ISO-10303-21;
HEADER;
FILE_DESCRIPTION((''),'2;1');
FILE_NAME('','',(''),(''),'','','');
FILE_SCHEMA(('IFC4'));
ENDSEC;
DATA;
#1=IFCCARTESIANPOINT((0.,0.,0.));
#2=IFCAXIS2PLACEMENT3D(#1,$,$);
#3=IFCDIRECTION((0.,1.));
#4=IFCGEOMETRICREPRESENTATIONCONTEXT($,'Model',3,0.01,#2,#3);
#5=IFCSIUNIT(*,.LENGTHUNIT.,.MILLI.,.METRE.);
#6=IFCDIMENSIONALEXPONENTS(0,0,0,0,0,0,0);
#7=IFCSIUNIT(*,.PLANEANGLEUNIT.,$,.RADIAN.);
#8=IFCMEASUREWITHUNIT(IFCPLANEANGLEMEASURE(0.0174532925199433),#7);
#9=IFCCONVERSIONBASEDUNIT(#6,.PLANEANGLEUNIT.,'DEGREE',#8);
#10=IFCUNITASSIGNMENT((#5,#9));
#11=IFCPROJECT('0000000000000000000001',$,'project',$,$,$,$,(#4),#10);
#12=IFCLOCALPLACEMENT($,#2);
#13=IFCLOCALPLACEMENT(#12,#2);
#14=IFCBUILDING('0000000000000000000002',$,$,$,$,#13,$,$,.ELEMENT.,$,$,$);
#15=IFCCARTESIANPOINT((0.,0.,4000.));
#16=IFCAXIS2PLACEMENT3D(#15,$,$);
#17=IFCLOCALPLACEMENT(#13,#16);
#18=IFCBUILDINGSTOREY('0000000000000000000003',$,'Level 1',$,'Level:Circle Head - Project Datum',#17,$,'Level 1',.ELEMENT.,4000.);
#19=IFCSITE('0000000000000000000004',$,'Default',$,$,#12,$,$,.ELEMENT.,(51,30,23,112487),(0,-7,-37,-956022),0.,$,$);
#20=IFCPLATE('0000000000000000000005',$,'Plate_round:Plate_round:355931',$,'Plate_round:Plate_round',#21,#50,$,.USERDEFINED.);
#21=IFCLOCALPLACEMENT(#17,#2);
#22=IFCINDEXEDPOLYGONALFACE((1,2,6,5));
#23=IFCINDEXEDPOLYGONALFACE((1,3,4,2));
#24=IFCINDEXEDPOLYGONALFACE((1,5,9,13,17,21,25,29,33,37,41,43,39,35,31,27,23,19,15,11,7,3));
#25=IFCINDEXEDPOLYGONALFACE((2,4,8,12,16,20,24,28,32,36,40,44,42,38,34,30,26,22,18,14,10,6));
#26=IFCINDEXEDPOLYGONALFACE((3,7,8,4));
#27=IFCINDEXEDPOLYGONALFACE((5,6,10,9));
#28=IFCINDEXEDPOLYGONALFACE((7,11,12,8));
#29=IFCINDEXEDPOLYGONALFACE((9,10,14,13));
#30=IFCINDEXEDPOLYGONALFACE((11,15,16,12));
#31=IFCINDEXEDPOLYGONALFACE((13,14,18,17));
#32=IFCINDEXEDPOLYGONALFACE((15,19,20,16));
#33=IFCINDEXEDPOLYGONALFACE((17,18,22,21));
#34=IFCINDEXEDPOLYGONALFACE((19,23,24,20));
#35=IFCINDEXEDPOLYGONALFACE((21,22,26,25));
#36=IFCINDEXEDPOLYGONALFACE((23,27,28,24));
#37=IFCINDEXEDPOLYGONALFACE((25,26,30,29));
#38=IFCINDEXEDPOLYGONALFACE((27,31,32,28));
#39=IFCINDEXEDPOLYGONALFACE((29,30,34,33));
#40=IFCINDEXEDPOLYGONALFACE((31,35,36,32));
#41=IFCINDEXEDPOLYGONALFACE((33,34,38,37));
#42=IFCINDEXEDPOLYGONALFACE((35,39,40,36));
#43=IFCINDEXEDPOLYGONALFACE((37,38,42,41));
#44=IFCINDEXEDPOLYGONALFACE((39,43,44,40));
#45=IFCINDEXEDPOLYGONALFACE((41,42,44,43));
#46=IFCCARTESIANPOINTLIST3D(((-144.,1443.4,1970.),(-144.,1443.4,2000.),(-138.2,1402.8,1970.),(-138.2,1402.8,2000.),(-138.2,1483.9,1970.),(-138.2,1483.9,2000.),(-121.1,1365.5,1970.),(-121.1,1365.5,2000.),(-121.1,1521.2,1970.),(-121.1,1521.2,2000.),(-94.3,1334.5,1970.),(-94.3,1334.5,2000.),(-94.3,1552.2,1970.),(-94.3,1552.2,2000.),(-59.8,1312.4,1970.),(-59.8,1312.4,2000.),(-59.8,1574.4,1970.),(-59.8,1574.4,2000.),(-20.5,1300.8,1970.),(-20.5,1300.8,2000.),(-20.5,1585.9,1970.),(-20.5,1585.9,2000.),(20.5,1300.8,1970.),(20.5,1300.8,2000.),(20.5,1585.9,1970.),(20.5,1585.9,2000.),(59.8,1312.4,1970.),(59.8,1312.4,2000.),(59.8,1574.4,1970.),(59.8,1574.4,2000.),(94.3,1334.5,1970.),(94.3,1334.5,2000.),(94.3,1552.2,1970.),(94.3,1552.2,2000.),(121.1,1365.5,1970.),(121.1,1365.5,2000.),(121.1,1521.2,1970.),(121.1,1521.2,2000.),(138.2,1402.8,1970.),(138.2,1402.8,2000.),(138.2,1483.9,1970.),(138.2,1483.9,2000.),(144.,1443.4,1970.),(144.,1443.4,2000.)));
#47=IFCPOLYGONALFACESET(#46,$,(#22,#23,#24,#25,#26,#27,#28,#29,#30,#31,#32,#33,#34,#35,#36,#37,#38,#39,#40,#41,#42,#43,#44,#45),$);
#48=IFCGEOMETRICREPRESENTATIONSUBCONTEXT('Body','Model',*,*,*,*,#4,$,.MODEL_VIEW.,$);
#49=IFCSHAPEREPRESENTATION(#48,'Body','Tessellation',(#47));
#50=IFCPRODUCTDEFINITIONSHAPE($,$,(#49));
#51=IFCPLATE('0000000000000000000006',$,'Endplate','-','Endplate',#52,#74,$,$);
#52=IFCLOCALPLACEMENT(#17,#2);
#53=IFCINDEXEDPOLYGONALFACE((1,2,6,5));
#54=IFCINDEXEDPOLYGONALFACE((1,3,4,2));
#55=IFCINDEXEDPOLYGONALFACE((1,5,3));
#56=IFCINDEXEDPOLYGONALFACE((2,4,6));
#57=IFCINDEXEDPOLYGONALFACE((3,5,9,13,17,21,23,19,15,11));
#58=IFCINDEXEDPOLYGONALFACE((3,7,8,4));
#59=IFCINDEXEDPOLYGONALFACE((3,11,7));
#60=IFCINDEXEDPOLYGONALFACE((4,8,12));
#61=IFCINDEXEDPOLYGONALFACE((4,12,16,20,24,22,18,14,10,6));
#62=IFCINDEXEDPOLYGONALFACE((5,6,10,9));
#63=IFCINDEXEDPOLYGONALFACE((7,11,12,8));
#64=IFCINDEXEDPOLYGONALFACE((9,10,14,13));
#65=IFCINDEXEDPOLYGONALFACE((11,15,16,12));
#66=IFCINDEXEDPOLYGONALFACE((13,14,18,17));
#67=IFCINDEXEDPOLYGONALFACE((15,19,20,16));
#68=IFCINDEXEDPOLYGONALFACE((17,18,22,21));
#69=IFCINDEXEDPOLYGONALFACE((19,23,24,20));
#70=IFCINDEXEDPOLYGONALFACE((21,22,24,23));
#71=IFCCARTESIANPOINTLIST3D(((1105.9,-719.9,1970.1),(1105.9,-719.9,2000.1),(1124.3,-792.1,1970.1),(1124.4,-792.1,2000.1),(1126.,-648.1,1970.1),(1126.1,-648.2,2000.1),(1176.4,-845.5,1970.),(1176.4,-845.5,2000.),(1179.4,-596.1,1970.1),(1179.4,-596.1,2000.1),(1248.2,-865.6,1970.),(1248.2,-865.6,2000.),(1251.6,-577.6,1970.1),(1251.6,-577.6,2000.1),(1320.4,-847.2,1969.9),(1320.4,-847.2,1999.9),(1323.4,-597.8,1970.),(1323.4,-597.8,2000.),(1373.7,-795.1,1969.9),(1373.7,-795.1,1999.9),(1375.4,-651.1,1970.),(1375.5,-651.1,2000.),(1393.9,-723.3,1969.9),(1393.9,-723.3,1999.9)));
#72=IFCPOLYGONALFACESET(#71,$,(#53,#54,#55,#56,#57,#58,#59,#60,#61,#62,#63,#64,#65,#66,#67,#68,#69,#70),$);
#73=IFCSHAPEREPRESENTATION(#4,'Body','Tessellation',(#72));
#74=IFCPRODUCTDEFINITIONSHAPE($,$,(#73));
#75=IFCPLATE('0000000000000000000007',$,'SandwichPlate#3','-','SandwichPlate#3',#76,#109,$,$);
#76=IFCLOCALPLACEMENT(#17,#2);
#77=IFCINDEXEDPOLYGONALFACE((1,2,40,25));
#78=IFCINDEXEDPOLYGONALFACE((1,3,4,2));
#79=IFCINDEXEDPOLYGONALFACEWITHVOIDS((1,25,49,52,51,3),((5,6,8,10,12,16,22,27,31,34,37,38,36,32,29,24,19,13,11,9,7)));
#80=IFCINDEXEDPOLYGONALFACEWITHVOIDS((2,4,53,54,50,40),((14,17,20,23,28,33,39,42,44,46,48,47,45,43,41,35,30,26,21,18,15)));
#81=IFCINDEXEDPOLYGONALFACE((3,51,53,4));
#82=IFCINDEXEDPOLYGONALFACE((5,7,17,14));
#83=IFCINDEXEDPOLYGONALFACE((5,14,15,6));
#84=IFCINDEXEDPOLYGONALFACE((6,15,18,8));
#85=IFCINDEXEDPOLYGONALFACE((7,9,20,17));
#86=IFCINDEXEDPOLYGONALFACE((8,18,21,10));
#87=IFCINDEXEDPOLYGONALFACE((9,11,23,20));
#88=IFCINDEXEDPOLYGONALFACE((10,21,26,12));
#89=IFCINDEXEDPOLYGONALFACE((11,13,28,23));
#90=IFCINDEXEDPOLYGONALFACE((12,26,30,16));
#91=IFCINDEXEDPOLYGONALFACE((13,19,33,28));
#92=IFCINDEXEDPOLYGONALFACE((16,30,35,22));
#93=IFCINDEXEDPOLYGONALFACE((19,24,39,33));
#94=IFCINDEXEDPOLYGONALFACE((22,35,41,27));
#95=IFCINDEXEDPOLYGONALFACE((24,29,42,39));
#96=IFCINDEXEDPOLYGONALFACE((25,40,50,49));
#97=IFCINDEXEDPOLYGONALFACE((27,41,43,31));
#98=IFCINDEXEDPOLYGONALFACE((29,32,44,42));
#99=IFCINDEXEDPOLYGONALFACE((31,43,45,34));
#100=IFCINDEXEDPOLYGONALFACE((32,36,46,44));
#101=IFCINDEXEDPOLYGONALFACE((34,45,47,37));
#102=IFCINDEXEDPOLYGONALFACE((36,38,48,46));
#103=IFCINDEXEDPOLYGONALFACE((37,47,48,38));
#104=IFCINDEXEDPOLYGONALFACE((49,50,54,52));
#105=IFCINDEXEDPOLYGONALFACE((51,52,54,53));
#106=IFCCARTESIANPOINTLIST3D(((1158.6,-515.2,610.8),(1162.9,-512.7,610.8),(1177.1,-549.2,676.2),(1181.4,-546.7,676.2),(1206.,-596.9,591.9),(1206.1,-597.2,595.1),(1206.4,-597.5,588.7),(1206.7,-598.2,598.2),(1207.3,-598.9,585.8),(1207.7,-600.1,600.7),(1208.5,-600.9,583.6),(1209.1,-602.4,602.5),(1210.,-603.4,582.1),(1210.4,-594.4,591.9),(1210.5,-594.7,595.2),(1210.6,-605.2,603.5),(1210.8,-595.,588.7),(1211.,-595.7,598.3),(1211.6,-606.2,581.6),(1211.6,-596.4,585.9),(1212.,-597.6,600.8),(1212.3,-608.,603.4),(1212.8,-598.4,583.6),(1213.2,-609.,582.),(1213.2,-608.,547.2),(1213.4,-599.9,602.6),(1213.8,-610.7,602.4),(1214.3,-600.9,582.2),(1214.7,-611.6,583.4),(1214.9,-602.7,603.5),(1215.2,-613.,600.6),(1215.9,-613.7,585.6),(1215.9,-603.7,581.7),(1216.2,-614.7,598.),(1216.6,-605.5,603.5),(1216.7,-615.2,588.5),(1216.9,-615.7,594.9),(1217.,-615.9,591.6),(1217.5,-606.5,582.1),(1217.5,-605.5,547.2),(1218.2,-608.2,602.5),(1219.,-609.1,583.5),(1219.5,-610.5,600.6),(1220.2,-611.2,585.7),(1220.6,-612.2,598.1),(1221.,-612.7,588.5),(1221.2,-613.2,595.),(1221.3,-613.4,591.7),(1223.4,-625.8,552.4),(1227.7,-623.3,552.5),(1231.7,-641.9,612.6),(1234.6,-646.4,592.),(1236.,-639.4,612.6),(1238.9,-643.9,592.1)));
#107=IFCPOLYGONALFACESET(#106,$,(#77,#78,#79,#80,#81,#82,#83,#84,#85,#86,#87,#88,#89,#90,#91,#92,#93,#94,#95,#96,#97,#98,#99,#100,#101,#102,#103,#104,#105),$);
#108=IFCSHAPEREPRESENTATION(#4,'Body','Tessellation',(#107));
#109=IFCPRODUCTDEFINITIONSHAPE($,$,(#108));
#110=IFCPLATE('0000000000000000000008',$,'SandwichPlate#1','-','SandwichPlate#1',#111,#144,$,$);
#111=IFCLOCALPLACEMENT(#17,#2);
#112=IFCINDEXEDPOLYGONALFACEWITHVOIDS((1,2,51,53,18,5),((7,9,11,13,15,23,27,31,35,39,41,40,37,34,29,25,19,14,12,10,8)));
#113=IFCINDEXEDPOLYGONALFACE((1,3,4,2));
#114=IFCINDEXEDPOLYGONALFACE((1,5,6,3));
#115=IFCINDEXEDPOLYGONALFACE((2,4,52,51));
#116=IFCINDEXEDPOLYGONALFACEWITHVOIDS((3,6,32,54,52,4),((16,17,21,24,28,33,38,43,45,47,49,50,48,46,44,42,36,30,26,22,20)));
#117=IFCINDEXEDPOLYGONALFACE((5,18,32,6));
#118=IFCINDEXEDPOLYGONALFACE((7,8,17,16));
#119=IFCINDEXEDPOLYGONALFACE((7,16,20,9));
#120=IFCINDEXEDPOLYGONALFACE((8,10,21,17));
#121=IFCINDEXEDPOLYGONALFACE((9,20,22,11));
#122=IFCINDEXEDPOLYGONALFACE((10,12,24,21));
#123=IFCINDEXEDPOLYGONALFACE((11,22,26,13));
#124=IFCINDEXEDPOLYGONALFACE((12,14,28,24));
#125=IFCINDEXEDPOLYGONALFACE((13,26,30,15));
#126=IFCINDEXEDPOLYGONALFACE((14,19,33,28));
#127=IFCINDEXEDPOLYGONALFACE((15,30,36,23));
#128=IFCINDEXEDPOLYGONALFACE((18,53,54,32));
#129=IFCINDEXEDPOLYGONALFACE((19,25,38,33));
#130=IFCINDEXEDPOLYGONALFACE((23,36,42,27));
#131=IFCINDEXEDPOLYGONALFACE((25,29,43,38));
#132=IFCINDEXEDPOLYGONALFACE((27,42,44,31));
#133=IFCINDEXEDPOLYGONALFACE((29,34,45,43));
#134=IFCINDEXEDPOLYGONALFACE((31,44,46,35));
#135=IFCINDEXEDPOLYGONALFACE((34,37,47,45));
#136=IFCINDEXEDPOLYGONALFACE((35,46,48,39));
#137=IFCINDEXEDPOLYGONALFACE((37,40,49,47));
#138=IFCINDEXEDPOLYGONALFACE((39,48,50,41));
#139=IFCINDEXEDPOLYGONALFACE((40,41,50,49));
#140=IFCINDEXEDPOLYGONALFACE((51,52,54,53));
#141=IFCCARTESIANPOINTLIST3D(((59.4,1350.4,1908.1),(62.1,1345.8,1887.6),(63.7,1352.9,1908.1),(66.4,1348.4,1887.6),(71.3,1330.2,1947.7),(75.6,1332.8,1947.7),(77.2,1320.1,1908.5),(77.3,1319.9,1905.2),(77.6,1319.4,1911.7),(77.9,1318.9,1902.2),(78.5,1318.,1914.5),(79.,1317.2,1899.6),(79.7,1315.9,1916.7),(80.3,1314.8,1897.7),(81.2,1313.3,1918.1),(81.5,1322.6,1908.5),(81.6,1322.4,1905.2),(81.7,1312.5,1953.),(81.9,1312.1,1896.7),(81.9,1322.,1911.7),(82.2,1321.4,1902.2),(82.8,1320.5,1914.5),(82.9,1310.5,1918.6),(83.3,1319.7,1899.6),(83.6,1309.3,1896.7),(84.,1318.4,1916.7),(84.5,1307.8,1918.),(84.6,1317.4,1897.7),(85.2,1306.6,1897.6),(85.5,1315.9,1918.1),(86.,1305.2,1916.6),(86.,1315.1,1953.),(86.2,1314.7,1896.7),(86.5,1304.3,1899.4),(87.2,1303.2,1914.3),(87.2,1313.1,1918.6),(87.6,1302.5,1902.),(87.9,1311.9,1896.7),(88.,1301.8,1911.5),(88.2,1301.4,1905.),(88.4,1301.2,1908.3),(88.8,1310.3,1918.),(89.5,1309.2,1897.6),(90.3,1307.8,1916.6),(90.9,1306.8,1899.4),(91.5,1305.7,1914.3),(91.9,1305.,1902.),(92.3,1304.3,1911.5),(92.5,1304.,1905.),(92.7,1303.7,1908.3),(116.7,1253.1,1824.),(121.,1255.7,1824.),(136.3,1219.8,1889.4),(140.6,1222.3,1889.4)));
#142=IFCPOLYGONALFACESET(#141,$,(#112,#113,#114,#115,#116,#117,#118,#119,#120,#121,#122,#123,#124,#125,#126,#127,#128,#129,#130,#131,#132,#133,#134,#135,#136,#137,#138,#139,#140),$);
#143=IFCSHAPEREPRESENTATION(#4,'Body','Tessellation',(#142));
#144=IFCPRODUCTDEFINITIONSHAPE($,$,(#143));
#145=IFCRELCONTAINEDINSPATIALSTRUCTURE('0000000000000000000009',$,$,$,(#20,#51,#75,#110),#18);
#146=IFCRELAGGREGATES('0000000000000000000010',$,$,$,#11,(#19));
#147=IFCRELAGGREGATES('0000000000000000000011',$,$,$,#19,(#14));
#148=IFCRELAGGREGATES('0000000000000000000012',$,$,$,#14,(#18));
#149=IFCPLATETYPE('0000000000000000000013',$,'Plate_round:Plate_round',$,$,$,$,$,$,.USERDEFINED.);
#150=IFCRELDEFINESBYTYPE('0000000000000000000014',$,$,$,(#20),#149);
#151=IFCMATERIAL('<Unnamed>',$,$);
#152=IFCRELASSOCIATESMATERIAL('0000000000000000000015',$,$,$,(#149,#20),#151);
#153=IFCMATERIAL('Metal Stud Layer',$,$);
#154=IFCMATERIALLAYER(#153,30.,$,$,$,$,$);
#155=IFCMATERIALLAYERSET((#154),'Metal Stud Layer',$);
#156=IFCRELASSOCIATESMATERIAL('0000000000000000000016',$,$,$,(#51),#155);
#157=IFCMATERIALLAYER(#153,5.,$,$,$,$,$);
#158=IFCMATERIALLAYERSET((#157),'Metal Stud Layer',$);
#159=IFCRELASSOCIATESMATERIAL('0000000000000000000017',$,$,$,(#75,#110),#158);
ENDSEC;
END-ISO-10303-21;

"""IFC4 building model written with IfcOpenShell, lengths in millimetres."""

from ifc_helpers import new_model, entity, si_unit, converted_unit, point, direction, frame, frame_2d, origin, origin_with_axes, origin_2d_with_axis, place, context, subcontext, project, spatial, polyline, arc, indexed_curve, circle_curve, line_curve, trimmed, segment, composite_curve, circle, outline, extrude, source, transform, mapped, material, layer, layer_set, type_object, type_shapes, element, save


model = new_model("IFC4")

# Units and contexts
model_context = context("Model", 3, precision=0.01, world=origin(), true_north=direction((0.0, 1.0)))
body_context = subcontext(model_context, "Body", "Model", "MODEL_VIEW")
ifc_project = project(units=[si_unit("LENGTHUNIT", "METRE", prefix="MILLI"), converted_unit("PLANEANGLEUNIT", "DEGREE", entity("IfcPlaneAngleMeasure", 0.0174532925199433), si_unit("PLANEANGLEUNIT", "RADIAN"), dimensions=[0, 0, 0, 0, 0, 0, 0])], contexts=[model_context])

# Site, building, storey
site_placement = place(None, origin())
site = spatial("IfcSite", under=ifc_project, at=site_placement, Name="Default", CompositionType="ELEMENT", RefLatitude=(51, 30, 23, 112487), RefLongitude=(0, -7, -37, -956022), RefElevation=0.0)
building_placement = place(site_placement, origin())
building = spatial("IfcBuilding", under=site, at=building_placement, CompositionType="ELEMENT")
storey_placement = place(building_placement, frame((0.0, 0.0, 4000.0)))
storey = spatial("IfcBuildingStorey", under=building, at=storey_placement, Name="Level 1", ObjectType="Level:Circle Head - Project Datum", LongName="Level 1", CompositionType="ELEMENT", Elevation=4000.0)

# Plate
ifc_material_1 = material(Name="<Unnamed>")
plate_type = type_object("IfcPlateType", Name="Plate_round:Plate_round", PredefinedType="USERDEFINED", material=ifc_material_1)
shared_shape = source(origin(), body_context, "Body", "SweptSolid", [
    extrude(outline(indexed_curve([(-144.0, 0.0), (0.0, -144.0), (144.0, 0.0), (0.0, 144.0)], segments=[arc(1, 2, 3), arc(3, 4, 1)], self_intersect=False)), origin(), (0.0, 0.0, 1.0), 30.0),
])
type_shapes(plate_type, [shared_shape])
plate_1_placement = place(storey_placement, frame((0.0, 1443.4, 1970.0)))
element("IfcPlate", 1, at=plate_1_placement, inside=storey, type_object=plate_type, material=ifc_material_1, Name="Plate_round:Plate_round:355931", ObjectType="Plate_round:Plate_round", PredefinedType="USERDEFINED", context=body_context, shape_type="MappedRepresentation", body=[
    mapped(shared_shape, transform((0.0, 0.0, 0.0), scale=1.0)),
])

# Plates, openings
ifc_material_2 = material(Name="Metal Stud Layer")
ifc_layer_1 = layer(ifc_material_2, 30.0)
ifc_layer_set_1 = layer_set([ifc_layer_1], Name="Metal Stud Layer")
plate_2_placement = place(storey_placement, frame((1323.4, -597.8, 1970.0), z_axis=(0.000702, -0.000406, 1.0), x_axis=(-0.860023, 0.510255, 0.000811)))
plate_2 = element("IfcPlate", 2, at=plate_2_placement, inside=storey, material=ifc_layer_set_1, Name="Endplate", Description="-", ObjectType="Endplate", context=model_context, shape_type="SweptSolid", body=[
    extrude(outline(polyline([(144.0, 0.0), (144.0, 288.0), (-144.0, 288.0), (-144.0, 0.0), (144.0, 0.0)])), origin_with_axes(), (0.0, 0.0, 1.0), 30.0),
])
opening_1_placement = place(plate_2_placement, frame((0.0, 0.0, 0.0), z_axis=(0.0, 0.0, 1.0), x_axis=(1.0, 0.0, 0.0)))
element("IfcOpeningElement", 3, at=opening_1_placement, cuts=plate_2, ObjectType="Opening", context=model_context, shape_type="SweptSolid", body=[
    extrude(outline(composite_curve([segment(trimmed(line_curve((144.0, 0.0), (0.0, 1.0), 144.0), [point((144.0, 0.0))], [point((144.0, 144.0))], True, "CARTESIAN"), True, "CONTINUOUS"), segment(trimmed(circle_curve(frame_2d((0.0, 144.0), x_axis=(-1.0, 0.0)), 144.0), [point((144.0, 144.0))], [point((0.0, 0.0))], False, "CARTESIAN"), True, "CONTINUOUS"), segment(trimmed(line_curve((0.0, 0.0), (1.0, 0.0), 144.0), [point((0.0, 0.0))], [point((144.0, 0.0))], True, "CARTESIAN"), True, "CONTINUOUS")], self_intersect="UNKNOWN")), origin(), (0.0, 0.0, 1.0), 30.0),
])
opening_2_placement = place(plate_2_placement, frame((0.0, 0.0, 0.0), z_axis=(0.0, 0.0, 1.0), x_axis=(1.0, 0.0, 0.0)))
element("IfcOpeningElement", 4, at=opening_2_placement, cuts=plate_2, ObjectType="Opening", context=model_context, shape_type="SweptSolid", body=[
    extrude(outline(composite_curve([segment(trimmed(line_curve((144.0, 288.0), (-1.0, 0.0), 144.0), [point((144.0, 288.0))], [point((0.0, 288.0))], True, "CARTESIAN"), True, "CONTINUOUS"), segment(trimmed(circle_curve(frame_2d((0.0, 144.0), x_axis=(-1.0, 0.0)), 144.0), [point((0.0, 288.0))], [point((144.0, 144.0))], False, "CARTESIAN"), True, "CONTINUOUS"), segment(trimmed(line_curve((144.0, 144.0), (0.0, 1.0), 144.0), [point((144.0, 144.0))], [point((144.0, 288.0))], True, "CARTESIAN"), True, "CONTINUOUS")], self_intersect="UNKNOWN")), origin(), (0.0, 0.0, 1.0), 30.0),
])
opening_3_placement = place(plate_2_placement, frame((0.0, 0.0, 0.0), z_axis=(0.0, 0.0, 1.0), x_axis=(1.0, 0.0, 0.0)))
element("IfcOpeningElement", 5, at=opening_3_placement, cuts=plate_2, ObjectType="Opening", context=model_context, shape_type="SweptSolid", body=[
    extrude(outline(composite_curve([segment(trimmed(line_curve((-144.0, 288.0), (0.0, -1.0), 144.0), [point((-144.0, 288.0))], [point((-144.0, 144.0))], True, "CARTESIAN"), True, "CONTINUOUS"), segment(trimmed(circle_curve(frame_2d((0.0, 144.0), x_axis=(-1.0, 0.0)), 144.0), [point((-144.0, 144.0))], [point((0.0, 288.0))], False, "CARTESIAN"), True, "CONTINUOUS"), segment(trimmed(line_curve((0.0, 288.0), (-1.0, 0.0), 144.0), [point((0.0, 288.0))], [point((-144.0, 288.0))], True, "CARTESIAN"), True, "CONTINUOUS")], self_intersect="UNKNOWN")), origin(), (0.0, 0.0, 1.0), 30.0),
])
opening_4_placement = place(plate_2_placement, frame((0.0, 0.0, 0.0), z_axis=(0.0, 0.0, 1.0), x_axis=(1.0, 0.0, 0.0)))
element("IfcOpeningElement", 6, at=opening_4_placement, cuts=plate_2, ObjectType="Opening", context=model_context, shape_type="SweptSolid", body=[
    extrude(outline(composite_curve([segment(trimmed(line_curve((-144.0, 0.0), (1.0, 0.0), 144.0), [point((-144.0, 0.0))], [point((0.0, 0.0))], True, "CARTESIAN"), True, "CONTINUOUS"), segment(trimmed(circle_curve(frame_2d((0.0, 144.0), x_axis=(-1.0, 0.0)), 144.0), [point((0.0, 0.0))], [point((-144.0, 144.0))], False, "CARTESIAN"), True, "CONTINUOUS"), segment(trimmed(line_curve((-144.0, 144.0), (0.0, -1.0), 144.0), [point((-144.0, 144.0))], [point((-144.0, 0.0))], True, "CARTESIAN"), True, "CONTINUOUS")], self_intersect="UNKNOWN")), origin(), (0.0, 0.0, 1.0), 30.0),
])
ifc_layer_2 = layer(ifc_material_2, 5.0)
ifc_layer_set_2 = layer_set([ifc_layer_2], Name="Metal Stud Layer")
plate_3_placement = place(storey_placement, frame((1224.1, -616.6, 539.6), z_axis=(-0.865935, -0.499948, -0.014432), x_axis=(0.243701, -0.44695, 0.860724)))
plate_3 = element("IfcPlate", 7, at=plate_3_placement, inside=storey, material=ifc_layer_set_2, Name="SandwichPlate#3", Description="-", ObjectType="SandwichPlate#3", context=model_context, shape_type="SweptSolid", body=[
    extrude(outline(polyline([(0.0, 0.0), (76.0, 0.0), (76.0, 140.0), (0.0, 140.0), (0.0, 0.0)])), origin_with_axes(), (0.0, 0.0, 1.0), 5.0),
])
opening_5_placement = place(plate_3_placement, frame((0.0, 0.0, 0.0), z_axis=(0.0, 0.0, 1.0), x_axis=(1.0, 0.0, 0.0)))
element("IfcOpeningElement", 8, at=opening_5_placement, cuts=plate_3, ObjectType="Opening", context=model_context, shape_type="SweptSolid", body=[
    extrude(outline(polyline([(0.0, 0.0), (15.0, 0.0), (0.0, 15.0), (0.0, 0.0)])), origin(), (0.0, 0.0, 1.0), 5.0),
])
opening_6_placement = place(plate_3_placement, frame((0.0, 0.0, 0.0), z_axis=(0.0, 0.0, 1.0), x_axis=(1.0, 0.0, 0.0)))
element("IfcOpeningElement", 9, at=opening_6_placement, cuts=plate_3, ObjectType="Opening", context=model_context, shape_type="SweptSolid", body=[
    extrude(outline(polyline([(76.0, 0.0), (76.0, 15.0), (61.0, 0.0), (76.0, 0.0)])), origin(), (0.0, 0.0, 1.0), 5.0),
])
opening_7_placement = place(plate_3_placement, frame((38.0, 40.0, -0.5), z_axis=(0.0, 0.0, 1.0), x_axis=(0.0, 1.0, 0.0)))
element("IfcOpeningElement", 10, at=opening_7_placement, cuts=plate_3, ObjectType="Opening", context=model_context, shape_type="SweptSolid", body=[
    extrude(circle(Radius=11.0, at=origin_2d_with_axis()), origin(), (0.0, 0.0, 1.0), 6.0),
])

# Plate, opening
plate_4_placement = place(storey_placement, frame((79.4, 1326.2, 1960.6), z_axis=(-0.861728, -0.507371, 0.0), x_axis=(-0.258184, 0.438505, -0.860845)))
plate_4 = element("IfcPlate", 11, at=plate_4_placement, inside=storey, material=ifc_layer_set_2, Name="SandwichPlate#1", Description="-", ObjectType="SandwichPlate#1", context=model_context, shape_type="SweptSolid", body=[
    extrude(outline(polyline([(15.0, 0.0), (61.0, 0.0), (76.0, 15.0), (76.0, 140.0), (0.0, 140.0), (0.0, 15.0), (15.0, 0.0)])), origin_with_axes(), (0.0, 0.0, 1.0), 5.0),
])
opening_8_placement = place(plate_4_placement, frame((38.0, 40.0, -0.5), z_axis=(0.0, 0.0, 1.0), x_axis=(0.0, 1.0, 0.0)))
element("IfcOpeningElement", 12, at=opening_8_placement, cuts=plate_4, ObjectType="Opening", context=model_context, shape_type="SweptSolid", body=[
    extrude(circle(Radius=11.0, at=origin_2d_with_axis()), origin(), (0.0, 0.0, 1.0), 6.0),
])

save(model, "model.ifc")
